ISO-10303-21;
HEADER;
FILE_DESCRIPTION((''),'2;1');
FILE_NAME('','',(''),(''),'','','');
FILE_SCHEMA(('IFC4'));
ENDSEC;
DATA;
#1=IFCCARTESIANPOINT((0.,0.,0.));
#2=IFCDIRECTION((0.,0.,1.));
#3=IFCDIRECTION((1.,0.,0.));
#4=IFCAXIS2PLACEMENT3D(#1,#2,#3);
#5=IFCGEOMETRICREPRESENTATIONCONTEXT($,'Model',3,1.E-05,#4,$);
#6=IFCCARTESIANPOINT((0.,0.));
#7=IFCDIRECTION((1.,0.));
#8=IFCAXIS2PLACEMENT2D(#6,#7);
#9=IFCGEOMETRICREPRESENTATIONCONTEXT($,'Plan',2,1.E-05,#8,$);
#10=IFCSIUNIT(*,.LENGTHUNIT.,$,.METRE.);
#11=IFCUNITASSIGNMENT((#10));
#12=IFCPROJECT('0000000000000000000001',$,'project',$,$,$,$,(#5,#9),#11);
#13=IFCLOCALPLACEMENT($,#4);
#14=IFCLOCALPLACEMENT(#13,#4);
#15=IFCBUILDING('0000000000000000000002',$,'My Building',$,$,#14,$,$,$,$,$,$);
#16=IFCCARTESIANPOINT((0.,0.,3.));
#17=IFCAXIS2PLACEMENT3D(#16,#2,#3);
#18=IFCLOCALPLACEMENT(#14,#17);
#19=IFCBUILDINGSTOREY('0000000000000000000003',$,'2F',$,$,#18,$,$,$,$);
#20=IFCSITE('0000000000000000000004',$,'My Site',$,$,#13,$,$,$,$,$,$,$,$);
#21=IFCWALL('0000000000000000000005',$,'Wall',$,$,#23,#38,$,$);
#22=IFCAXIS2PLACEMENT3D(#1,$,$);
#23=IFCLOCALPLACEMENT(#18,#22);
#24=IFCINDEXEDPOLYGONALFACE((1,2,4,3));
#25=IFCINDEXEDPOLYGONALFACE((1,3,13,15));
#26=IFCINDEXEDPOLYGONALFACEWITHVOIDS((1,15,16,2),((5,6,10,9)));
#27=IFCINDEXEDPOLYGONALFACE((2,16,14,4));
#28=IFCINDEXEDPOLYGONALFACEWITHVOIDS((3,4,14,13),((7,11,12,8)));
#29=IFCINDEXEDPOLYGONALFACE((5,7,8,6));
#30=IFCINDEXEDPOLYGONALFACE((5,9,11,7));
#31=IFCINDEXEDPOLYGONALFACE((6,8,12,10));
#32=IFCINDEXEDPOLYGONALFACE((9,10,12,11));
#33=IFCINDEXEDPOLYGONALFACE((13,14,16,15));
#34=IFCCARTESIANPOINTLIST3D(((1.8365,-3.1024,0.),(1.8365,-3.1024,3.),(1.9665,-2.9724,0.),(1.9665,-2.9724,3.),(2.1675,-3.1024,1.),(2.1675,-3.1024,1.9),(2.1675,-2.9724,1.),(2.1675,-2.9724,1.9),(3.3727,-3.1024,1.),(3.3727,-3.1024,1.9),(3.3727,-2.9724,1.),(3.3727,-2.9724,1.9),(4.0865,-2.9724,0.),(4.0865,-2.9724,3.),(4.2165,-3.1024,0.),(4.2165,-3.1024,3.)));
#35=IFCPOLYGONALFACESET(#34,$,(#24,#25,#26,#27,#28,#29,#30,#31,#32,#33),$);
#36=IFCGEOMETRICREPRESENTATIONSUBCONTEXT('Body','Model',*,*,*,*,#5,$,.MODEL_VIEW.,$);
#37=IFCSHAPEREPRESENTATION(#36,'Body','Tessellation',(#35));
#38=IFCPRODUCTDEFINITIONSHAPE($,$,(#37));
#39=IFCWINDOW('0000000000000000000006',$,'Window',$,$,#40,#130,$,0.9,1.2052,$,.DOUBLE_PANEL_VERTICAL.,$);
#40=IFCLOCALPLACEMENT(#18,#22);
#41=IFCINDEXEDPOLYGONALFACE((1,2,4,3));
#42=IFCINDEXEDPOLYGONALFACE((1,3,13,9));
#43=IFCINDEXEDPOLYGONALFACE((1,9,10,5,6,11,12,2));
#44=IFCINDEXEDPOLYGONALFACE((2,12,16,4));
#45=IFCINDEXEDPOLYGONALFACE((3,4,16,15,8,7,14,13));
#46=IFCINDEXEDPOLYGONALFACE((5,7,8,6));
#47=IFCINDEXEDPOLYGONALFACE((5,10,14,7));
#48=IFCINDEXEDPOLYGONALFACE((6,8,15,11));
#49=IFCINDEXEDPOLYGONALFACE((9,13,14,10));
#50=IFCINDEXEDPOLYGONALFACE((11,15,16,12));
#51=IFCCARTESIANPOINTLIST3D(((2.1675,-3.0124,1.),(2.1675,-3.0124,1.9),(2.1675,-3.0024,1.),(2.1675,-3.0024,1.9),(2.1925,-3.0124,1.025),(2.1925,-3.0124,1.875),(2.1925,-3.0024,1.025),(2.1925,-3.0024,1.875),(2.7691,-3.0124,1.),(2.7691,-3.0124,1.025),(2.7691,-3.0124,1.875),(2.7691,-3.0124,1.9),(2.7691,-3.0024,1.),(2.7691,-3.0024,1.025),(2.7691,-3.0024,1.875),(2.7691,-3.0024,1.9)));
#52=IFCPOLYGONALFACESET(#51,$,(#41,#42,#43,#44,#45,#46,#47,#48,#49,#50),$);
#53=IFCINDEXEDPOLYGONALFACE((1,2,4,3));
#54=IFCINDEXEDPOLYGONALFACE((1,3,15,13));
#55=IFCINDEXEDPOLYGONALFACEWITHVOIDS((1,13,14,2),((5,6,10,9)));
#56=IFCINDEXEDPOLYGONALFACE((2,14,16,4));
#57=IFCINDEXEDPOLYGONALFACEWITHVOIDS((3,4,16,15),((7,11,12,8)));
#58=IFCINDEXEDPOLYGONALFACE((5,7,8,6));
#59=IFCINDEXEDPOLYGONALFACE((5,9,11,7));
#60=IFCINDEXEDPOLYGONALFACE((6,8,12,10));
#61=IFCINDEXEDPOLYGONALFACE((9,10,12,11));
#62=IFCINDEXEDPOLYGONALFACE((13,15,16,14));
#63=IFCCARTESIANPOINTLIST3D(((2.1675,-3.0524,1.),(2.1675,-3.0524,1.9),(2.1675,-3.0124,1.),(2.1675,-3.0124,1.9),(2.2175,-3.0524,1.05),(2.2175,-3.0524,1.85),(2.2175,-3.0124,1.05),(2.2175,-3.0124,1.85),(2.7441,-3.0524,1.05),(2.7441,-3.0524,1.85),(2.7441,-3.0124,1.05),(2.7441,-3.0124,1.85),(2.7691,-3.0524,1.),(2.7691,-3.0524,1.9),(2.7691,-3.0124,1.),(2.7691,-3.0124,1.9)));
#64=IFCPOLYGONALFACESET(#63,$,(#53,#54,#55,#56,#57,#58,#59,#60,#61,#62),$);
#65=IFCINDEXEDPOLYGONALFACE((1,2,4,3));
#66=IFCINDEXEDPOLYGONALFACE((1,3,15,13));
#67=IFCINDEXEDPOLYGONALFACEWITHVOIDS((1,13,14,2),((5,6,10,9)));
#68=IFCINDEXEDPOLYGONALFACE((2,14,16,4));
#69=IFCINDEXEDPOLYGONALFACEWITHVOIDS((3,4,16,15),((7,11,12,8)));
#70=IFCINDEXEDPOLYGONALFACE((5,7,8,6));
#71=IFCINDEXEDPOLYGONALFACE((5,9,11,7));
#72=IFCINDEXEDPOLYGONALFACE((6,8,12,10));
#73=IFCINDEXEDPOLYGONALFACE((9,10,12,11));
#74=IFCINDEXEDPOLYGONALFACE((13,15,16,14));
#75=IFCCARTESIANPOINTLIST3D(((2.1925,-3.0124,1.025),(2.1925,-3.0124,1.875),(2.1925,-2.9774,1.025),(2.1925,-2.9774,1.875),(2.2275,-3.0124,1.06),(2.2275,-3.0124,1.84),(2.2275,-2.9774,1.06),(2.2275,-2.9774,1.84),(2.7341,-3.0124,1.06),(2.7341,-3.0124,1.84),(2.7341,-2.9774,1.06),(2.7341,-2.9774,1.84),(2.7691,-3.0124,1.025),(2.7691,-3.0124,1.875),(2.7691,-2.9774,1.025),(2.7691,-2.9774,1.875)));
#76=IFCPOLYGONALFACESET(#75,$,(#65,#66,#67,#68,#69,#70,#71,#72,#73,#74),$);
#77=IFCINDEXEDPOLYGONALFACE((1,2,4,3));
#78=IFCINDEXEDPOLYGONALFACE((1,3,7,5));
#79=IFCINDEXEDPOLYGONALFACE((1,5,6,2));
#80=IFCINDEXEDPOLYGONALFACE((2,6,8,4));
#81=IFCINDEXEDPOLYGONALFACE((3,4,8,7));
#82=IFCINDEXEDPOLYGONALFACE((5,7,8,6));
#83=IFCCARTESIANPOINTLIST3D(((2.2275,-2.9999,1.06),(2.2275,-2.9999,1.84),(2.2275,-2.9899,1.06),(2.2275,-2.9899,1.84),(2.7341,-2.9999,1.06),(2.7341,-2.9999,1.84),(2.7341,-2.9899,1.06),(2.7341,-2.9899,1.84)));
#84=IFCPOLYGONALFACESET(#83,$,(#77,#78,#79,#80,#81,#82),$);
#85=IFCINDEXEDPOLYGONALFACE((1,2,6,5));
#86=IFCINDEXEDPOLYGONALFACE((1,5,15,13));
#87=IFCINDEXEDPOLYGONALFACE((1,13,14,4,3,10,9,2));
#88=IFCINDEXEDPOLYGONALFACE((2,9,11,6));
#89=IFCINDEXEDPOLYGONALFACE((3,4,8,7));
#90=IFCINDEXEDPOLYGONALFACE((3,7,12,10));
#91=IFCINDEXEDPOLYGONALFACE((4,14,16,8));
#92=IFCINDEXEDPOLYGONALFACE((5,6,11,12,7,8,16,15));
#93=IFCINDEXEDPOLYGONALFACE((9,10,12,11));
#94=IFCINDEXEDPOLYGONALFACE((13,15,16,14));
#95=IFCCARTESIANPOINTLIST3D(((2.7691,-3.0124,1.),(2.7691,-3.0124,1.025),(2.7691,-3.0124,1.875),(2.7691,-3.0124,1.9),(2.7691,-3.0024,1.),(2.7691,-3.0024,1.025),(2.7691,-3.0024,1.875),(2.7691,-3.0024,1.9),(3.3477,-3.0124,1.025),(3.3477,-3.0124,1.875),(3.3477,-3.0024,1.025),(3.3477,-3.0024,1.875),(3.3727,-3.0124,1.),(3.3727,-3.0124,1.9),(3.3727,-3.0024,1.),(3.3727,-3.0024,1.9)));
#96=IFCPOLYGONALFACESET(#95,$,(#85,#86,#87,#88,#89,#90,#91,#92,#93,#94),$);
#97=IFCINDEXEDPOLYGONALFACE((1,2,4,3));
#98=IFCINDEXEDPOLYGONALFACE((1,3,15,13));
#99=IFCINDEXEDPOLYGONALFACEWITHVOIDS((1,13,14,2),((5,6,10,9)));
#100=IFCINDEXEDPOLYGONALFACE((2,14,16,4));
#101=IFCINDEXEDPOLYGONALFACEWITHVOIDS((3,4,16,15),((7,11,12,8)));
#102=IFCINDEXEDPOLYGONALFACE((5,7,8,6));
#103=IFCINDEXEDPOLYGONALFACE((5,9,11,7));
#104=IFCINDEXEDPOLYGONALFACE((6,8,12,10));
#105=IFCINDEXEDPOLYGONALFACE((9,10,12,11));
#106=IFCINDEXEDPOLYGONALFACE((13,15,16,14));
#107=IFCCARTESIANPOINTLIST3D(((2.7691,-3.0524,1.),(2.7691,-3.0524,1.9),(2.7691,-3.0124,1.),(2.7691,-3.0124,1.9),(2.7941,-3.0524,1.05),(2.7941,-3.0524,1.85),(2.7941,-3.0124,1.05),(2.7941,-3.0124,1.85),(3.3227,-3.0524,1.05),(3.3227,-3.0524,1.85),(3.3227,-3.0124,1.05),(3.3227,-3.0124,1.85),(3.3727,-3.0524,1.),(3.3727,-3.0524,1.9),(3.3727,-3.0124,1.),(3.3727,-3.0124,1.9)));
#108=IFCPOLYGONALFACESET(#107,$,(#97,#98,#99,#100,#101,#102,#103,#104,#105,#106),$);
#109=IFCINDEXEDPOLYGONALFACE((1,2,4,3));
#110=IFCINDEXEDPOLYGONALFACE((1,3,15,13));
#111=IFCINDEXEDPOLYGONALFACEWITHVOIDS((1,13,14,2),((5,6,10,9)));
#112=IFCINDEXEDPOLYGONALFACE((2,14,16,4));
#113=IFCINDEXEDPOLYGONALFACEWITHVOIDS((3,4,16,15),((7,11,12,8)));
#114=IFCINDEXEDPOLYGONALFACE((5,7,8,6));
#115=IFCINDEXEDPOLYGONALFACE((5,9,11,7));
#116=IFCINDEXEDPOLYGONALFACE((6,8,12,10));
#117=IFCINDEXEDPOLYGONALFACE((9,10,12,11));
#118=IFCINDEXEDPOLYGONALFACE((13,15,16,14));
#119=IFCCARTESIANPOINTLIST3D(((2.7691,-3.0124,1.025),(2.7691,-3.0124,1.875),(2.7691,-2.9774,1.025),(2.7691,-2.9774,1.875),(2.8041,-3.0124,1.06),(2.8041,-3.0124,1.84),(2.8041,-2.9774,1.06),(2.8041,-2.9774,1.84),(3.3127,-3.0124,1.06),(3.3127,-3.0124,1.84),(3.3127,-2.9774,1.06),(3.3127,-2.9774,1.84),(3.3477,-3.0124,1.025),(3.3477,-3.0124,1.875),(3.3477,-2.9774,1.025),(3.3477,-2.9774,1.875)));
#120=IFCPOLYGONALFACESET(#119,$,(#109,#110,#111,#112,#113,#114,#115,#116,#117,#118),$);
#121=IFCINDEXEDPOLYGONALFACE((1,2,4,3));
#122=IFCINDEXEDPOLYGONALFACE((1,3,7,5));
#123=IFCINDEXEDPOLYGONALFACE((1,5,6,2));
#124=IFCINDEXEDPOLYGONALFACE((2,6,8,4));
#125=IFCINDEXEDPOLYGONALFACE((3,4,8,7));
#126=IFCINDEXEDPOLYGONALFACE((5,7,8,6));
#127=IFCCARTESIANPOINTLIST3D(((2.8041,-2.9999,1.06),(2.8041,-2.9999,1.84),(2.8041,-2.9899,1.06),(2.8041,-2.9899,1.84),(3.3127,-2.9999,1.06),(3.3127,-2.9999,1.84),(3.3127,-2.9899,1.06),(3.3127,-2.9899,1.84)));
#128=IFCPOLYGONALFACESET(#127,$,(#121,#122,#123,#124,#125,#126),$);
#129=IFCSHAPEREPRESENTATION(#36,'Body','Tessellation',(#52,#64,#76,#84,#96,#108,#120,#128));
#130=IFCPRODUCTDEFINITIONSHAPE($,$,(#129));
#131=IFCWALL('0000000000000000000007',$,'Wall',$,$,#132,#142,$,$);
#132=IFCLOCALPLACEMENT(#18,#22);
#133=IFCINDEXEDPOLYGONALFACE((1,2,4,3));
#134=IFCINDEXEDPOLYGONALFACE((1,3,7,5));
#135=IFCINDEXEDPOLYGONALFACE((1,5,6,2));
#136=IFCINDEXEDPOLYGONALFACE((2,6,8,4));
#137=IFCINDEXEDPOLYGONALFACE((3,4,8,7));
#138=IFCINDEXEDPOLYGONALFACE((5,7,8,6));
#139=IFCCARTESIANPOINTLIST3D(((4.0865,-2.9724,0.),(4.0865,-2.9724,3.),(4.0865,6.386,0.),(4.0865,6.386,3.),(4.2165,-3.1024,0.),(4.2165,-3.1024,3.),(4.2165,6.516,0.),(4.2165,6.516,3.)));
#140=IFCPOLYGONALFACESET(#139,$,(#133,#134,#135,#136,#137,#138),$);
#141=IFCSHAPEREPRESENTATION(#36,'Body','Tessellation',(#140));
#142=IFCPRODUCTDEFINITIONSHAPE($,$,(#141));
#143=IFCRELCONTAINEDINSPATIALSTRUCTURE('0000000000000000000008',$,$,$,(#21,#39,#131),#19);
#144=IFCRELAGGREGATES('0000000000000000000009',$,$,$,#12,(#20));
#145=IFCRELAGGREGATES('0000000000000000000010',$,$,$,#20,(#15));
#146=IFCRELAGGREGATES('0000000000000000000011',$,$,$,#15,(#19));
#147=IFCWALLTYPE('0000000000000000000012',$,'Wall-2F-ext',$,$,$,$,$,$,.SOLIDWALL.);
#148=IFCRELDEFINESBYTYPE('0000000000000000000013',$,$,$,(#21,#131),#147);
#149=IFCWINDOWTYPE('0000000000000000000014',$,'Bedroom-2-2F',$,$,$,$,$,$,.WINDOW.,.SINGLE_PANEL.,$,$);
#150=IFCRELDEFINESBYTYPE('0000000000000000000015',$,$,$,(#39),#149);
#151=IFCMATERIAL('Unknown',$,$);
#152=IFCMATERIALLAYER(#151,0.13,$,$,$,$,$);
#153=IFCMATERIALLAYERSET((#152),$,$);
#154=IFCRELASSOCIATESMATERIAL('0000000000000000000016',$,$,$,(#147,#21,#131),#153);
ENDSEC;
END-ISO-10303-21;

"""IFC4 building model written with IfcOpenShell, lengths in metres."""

from ifc_helpers import new_model, entity, si_unit, frame, origin_with_axes, origin_2d_with_axis, place, context, subcontext, project, spatial, line, indexed_curve, outline, extrude, shape, source, transform, mapped, material, layer, layer_set, layer_usage, type_object, type_shapes, element, fill, save


model = new_model("IFC4")

# Units and contexts
model_context = context("Model", 3, precision=1e-05, world=origin_with_axes())
plan_context = context("Plan", 2, precision=1e-05, world=origin_2d_with_axis())
body_context_1 = subcontext(model_context, "Body", "Model", "MODEL_VIEW")
body_context_2 = subcontext(plan_context, "Body", "Plan", "PLAN_VIEW")
ifc_project = project(units=[si_unit("LENGTHUNIT", "METRE")], contexts=[model_context, plan_context])

# Site, building, storey
site_placement = place(None, origin_with_axes())
site = spatial("IfcSite", under=ifc_project, at=site_placement, Name="My Site")
building_placement = place(site_placement, origin_with_axes())
building = spatial("IfcBuilding", under=site, at=building_placement, Name="My Building")
storey_placement = place(building_placement, frame((0.0, 0.0, 3.0), z_axis=(0.0, 0.0, 1.0), x_axis=(1.0, 0.0, 0.0)))
storey = spatial("IfcBuildingStorey", under=building, at=storey_placement, Name="2F")

# Shared definitions
ifc_material = material(Name="Unknown")

# Shared definitions
ifc_layer_1 = layer(ifc_material, 0.13)
ifc_layer_set_1 = layer_set([ifc_layer_1])
wall_type_1 = type_object("IfcWallType", Name="Wall-2F-ext", PredefinedType="SOLIDWALL", material=ifc_layer_set_1)

# Wall, opening, window
ifc_layer_usage_1 = layer_usage(ifc_layer_set_1, "AXIS2", "POSITIVE", 0.0)
wall_1_placement = place(storey_placement, frame((1.8365, -3.1024, 0.0), z_axis=(0.0, 0.0, 1.0), x_axis=(1.0, 0.0, 0.0)))
wall_1 = element("IfcWall", 1, at=wall_1_placement, inside=storey, type_object=wall_type_1, material=ifc_layer_usage_1, Name="Wall", context=body_context_1, shape_type="SweptSolid", body=[
    extrude(outline(indexed_curve([(0.0, 0.0), (0.13, 0.13), (2.25, 0.13), (2.38, 0.0)], segments=[line(1, 2, 3, 4, 1)])), origin_with_axes(), (0.0, 0.0, 1.0), 3.0),
])
shared_shape_1 = source(origin_with_axes(), body_context_1, "Body", "SweptSolid", [
    extrude(outline(indexed_curve([(0.0, 0.0), (1.2052, 0.0), (1.2052, 0.9), (0.0, 0.9)], segments=[line(1, 2, 3, 4, 1)])), frame((0.0, -0.6, 0.0), z_axis=(0.0, -1.0, 0.0), x_axis=(1.0, 0.0, 0.0)), (0.0, 0.0, -1.0), 1.2),
])
opening_1_placement = place(wall_1_placement, frame((0.331, 0.0, 1.0), z_axis=(0.0, 0.0, 1.0), x_axis=(1.0, 0.0, 0.0)))
opening_1 = element("IfcOpeningElement", 2, at=opening_1_placement, cuts=wall_1, PredefinedType="OPENING", context=body_context_1, shape_type="MappedRepresentation", body=[
    mapped(shared_shape_1, transform((0.0, 0.0, 0.0), x_axis=(1.0, 0.0, 0.0), y_axis=(0.0, 1.0, 0.0), z_axis=(0.0, 0.0, 1.0), scale=1.0)),
])
window_type_1 = type_object("IfcWindowType", Name="Bedroom-2-2F", PartitioningType="SINGLE_PANEL", PredefinedType="WINDOW")
shared_shape_2 = source(origin_with_axes(), body_context_1, "Body", "SweptSolid", [
    extrude(outline(indexed_curve([(0.6015, 0.0), (0.0, 0.0), (0.0, 0.9), (0.6015, 0.9), (0.6015, 0.875), (0.025, 0.875), (0.025, 0.025), (0.6015, 0.025)], segments=[line(1, 2, 3, 4, 5, 6, 7, 8, 1)])), frame((0.0, 0.09, 0.0), z_axis=(0.0, -1.0, 0.0), x_axis=(1.0, 0.0, 0.0)), (0.0, 0.0, -1.0), 0.01),
    extrude(outline(indexed_curve([(0.0, 0.0), (0.6015, 0.0), (0.6015, 0.9), (0.0, 0.9)], segments=[line(1, 2, 3, 4, 1)]), holes=[indexed_curve([(0.05, 0.05), (0.5765, 0.05), (0.5765, 0.85), (0.05, 0.85)], segments=[line(1, 2, 3, 4, 1)])]), frame((0.0, 0.05, 0.0), z_axis=(0.0, -1.0, 0.0), x_axis=(1.0, 0.0, 0.0)), (0.0, 0.0, -1.0), 0.04),
    extrude(outline(indexed_curve([(0.0, 0.0), (0.5765, 0.0), (0.5765, 0.85), (0.0, 0.85)], segments=[line(1, 2, 3, 4, 1)]), holes=[indexed_curve([(0.035, 0.035), (0.5415, 0.035), (0.5415, 0.815), (0.035, 0.815)], segments=[line(1, 2, 3, 4, 1)])]), frame((0.025, 0.09, 0.025), z_axis=(0.0, -1.0, 0.0), x_axis=(1.0, 0.0, 0.0)), (0.0, 0.0, -1.0), 0.035),
    extrude(outline(indexed_curve([(0.035, 0.035), (0.5415, 0.035), (0.5415, 0.815), (0.035, 0.815)], segments=[line(1, 2, 3, 4, 1)])), frame((0.025, 0.1025, 0.025), z_axis=(0.0, -1.0, 0.0), x_axis=(1.0, 0.0, 0.0)), (0.0, 0.0, -1.0), 0.01),
    extrude(outline(indexed_curve([(0.0, 0.9), (0.6036, 0.9), (0.6036, 0.0), (0.0, 0.0), (0.0, 0.025), (0.5786, 0.025), (0.5786, 0.875), (0.0, 0.875)], segments=[line(1, 2, 3, 4, 5, 6, 7, 8, 1)])), frame((0.6015, 0.09, 0.0), z_axis=(0.0, -1.0, 0.0), x_axis=(1.0, 0.0, 0.0)), (0.0, 0.0, -1.0), 0.01),
    extrude(outline(indexed_curve([(0.0, 0.0), (0.6036, 0.0), (0.6036, 0.9), (0.0, 0.9)], segments=[line(1, 2, 3, 4, 1)]), holes=[indexed_curve([(0.025, 0.05), (0.5536, 0.05), (0.5536, 0.85), (0.025, 0.85)], segments=[line(1, 2, 3, 4, 1)])]), frame((0.6015, 0.05, 0.0), z_axis=(0.0, -1.0, 0.0), x_axis=(1.0, 0.0, 0.0)), (0.0, 0.0, -1.0), 0.04),
    extrude(outline(indexed_curve([(0.0, 0.0), (0.5786, 0.0), (0.5786, 0.85), (0.0, 0.85)], segments=[line(1, 2, 3, 4, 1)]), holes=[indexed_curve([(0.035, 0.035), (0.5436, 0.035), (0.5436, 0.815), (0.035, 0.815)], segments=[line(1, 2, 3, 4, 1)])]), frame((0.6015, 0.09, 0.025), z_axis=(0.0, -1.0, 0.0), x_axis=(1.0, 0.0, 0.0)), (0.0, 0.0, -1.0), 0.035),
    extrude(outline(indexed_curve([(0.035, 0.035), (0.5436, 0.035), (0.5436, 0.815), (0.035, 0.815)], segments=[line(1, 2, 3, 4, 1)])), frame((0.6015, 0.1025, 0.025), z_axis=(0.0, -1.0, 0.0), x_axis=(1.0, 0.0, 0.0)), (0.0, 0.0, -1.0), 0.01),
])
shared_shape_3 = source(origin_with_axes(), body_context_2, "Body", "Curve2D", [
    entity("IfcIndexedPolyCurve", entity("IfcCartesianPointList2D", [[0.05, 0.05], [0.5765, 0.05]])),
    entity("IfcIndexedPolyCurve", entity("IfcCartesianPointList2D", [[0.0, 0.1], [0.025, 0.1], [0.025, 0.09], [0.05, 0.09], [0.05, 0.05], [0.0, 0.05]]), [entity("IfcLineIndex", [1, 2, 3, 4, 5, 6, 1])]),
    entity("IfcIndexedPolyCurve", entity("IfcCartesianPointList2D", [[0.6015, 0.1], [0.6015, 0.1], [0.6015, 0.09], [0.5765, 0.09], [0.5765, 0.05], [0.6015, 0.05]])),
    entity("IfcIndexedPolyCurve", entity("IfcCartesianPointList2D", [[0.025, 0.09], [0.06, 0.09], [0.06, 0.125], [0.025, 0.125]]), [entity("IfcLineIndex", [1, 2, 3, 4, 1])]),
    entity("IfcIndexedPolyCurve", entity("IfcCartesianPointList2D", [[0.6015, 0.09], [0.5665, 0.09], [0.5665, 0.125], [0.6015, 0.125]]), [entity("IfcLineIndex", [1, 2, 3, 4, 1])]),
    entity("IfcIndexedPolyCurve", entity("IfcCartesianPointList2D", [[0.06, 0.09], [0.5665, 0.09]])),
    entity("IfcIndexedPolyCurve", entity("IfcCartesianPointList2D", [[0.06, 0.125], [0.5665, 0.125]])),
    entity("IfcIndexedPolyCurve", entity("IfcCartesianPointList2D", [[0.06, 0.1075], [0.5665, 0.1075]])),
    entity("IfcIndexedPolyCurve", entity("IfcCartesianPointList2D", [[0.6265, 0.05], [1.1552, 0.05]])),
    entity("IfcIndexedPolyCurve", entity("IfcCartesianPointList2D", [[0.6015, 0.1], [0.6015, 0.1], [0.6015, 0.09], [0.6265, 0.09], [0.6265, 0.05], [0.6015, 0.05]])),
    entity("IfcIndexedPolyCurve", entity("IfcCartesianPointList2D", [[1.2052, 0.1], [1.1802, 0.1], [1.1802, 0.09], [1.1552, 0.09], [1.1552, 0.05], [1.2052, 0.05]]), [entity("IfcLineIndex", [1, 2, 3, 4, 5, 6, 1])]),
    entity("IfcIndexedPolyCurve", entity("IfcCartesianPointList2D", [[0.6015, 0.09], [0.6365, 0.09], [0.6365, 0.125], [0.6015, 0.125]]), [entity("IfcLineIndex", [1, 2, 3, 4, 1])]),
    entity("IfcIndexedPolyCurve", entity("IfcCartesianPointList2D", [[1.1802, 0.09], [1.1452, 0.09], [1.1452, 0.125], [1.1802, 0.125]]), [entity("IfcLineIndex", [1, 2, 3, 4, 1])]),
    entity("IfcIndexedPolyCurve", entity("IfcCartesianPointList2D", [[0.6365, 0.09], [1.1452, 0.09]])),
    entity("IfcIndexedPolyCurve", entity("IfcCartesianPointList2D", [[0.6365, 0.125], [1.1452, 0.125]])),
    entity("IfcIndexedPolyCurve", entity("IfcCartesianPointList2D", [[0.6365, 0.1075], [1.1452, 0.1075]])),
])
type_shapes(window_type_1, [shared_shape_2, shared_shape_3])
window_1_placement = place(opening_1_placement, frame((0.0, 0.0, 0.0), z_axis=(0.0, 0.0, 1.0), x_axis=(1.0, 0.0, 0.0)))
window_1 = element("IfcWindow", 3, at=window_1_placement, inside=storey, type_object=window_type_1, Name="Window", OverallHeight=0.9, OverallWidth=1.2052, PartitioningType="DOUBLE_PANEL_VERTICAL", shapes=[
    shape(body_context_1, "Body", "MappedRepresentation", [mapped(shared_shape_2, transform((0.0, 0.0, 0.0), x_axis=(1.0, 0.0, 0.0), y_axis=(0.0, 1.0, 0.0), z_axis=(0.0, 0.0, 1.0), scale=1.0))]),
    shape(body_context_2, "Body", "MappedRepresentation", [mapped(shared_shape_3, transform((0.0, 0.0, 0.0), x_axis=(1.0, 0.0, 0.0), y_axis=(0.0, 1.0, 0.0), z_axis=(0.0, 0.0, 1.0), scale=1.0))]),
])
fill(opening_1, window_1)

# Wall
ifc_layer_usage_2 = layer_usage(ifc_layer_set_1, "AXIS2", "POSITIVE", 0.0)
wall_2_placement = place(storey_placement, frame((4.2165, -3.1024, 0.0), z_axis=(0.0, 0.0, 1.0), x_axis=(0.0, 1.0, 0.0)))
element("IfcWall", 4, at=wall_2_placement, inside=storey, type_object=wall_type_1, material=ifc_layer_usage_2, Name="Wall", context=body_context_1, shape_type="SweptSolid", body=[
    extrude(outline(indexed_curve([(0.0, 0.0), (0.13, 0.13), (9.4884, 0.13), (9.6184, 0.0)], segments=[line(1, 2, 3, 4, 1)])), origin_with_axes(), (0.0, 0.0, 1.0), 3.0),
])

save(model, "model.ifc")
